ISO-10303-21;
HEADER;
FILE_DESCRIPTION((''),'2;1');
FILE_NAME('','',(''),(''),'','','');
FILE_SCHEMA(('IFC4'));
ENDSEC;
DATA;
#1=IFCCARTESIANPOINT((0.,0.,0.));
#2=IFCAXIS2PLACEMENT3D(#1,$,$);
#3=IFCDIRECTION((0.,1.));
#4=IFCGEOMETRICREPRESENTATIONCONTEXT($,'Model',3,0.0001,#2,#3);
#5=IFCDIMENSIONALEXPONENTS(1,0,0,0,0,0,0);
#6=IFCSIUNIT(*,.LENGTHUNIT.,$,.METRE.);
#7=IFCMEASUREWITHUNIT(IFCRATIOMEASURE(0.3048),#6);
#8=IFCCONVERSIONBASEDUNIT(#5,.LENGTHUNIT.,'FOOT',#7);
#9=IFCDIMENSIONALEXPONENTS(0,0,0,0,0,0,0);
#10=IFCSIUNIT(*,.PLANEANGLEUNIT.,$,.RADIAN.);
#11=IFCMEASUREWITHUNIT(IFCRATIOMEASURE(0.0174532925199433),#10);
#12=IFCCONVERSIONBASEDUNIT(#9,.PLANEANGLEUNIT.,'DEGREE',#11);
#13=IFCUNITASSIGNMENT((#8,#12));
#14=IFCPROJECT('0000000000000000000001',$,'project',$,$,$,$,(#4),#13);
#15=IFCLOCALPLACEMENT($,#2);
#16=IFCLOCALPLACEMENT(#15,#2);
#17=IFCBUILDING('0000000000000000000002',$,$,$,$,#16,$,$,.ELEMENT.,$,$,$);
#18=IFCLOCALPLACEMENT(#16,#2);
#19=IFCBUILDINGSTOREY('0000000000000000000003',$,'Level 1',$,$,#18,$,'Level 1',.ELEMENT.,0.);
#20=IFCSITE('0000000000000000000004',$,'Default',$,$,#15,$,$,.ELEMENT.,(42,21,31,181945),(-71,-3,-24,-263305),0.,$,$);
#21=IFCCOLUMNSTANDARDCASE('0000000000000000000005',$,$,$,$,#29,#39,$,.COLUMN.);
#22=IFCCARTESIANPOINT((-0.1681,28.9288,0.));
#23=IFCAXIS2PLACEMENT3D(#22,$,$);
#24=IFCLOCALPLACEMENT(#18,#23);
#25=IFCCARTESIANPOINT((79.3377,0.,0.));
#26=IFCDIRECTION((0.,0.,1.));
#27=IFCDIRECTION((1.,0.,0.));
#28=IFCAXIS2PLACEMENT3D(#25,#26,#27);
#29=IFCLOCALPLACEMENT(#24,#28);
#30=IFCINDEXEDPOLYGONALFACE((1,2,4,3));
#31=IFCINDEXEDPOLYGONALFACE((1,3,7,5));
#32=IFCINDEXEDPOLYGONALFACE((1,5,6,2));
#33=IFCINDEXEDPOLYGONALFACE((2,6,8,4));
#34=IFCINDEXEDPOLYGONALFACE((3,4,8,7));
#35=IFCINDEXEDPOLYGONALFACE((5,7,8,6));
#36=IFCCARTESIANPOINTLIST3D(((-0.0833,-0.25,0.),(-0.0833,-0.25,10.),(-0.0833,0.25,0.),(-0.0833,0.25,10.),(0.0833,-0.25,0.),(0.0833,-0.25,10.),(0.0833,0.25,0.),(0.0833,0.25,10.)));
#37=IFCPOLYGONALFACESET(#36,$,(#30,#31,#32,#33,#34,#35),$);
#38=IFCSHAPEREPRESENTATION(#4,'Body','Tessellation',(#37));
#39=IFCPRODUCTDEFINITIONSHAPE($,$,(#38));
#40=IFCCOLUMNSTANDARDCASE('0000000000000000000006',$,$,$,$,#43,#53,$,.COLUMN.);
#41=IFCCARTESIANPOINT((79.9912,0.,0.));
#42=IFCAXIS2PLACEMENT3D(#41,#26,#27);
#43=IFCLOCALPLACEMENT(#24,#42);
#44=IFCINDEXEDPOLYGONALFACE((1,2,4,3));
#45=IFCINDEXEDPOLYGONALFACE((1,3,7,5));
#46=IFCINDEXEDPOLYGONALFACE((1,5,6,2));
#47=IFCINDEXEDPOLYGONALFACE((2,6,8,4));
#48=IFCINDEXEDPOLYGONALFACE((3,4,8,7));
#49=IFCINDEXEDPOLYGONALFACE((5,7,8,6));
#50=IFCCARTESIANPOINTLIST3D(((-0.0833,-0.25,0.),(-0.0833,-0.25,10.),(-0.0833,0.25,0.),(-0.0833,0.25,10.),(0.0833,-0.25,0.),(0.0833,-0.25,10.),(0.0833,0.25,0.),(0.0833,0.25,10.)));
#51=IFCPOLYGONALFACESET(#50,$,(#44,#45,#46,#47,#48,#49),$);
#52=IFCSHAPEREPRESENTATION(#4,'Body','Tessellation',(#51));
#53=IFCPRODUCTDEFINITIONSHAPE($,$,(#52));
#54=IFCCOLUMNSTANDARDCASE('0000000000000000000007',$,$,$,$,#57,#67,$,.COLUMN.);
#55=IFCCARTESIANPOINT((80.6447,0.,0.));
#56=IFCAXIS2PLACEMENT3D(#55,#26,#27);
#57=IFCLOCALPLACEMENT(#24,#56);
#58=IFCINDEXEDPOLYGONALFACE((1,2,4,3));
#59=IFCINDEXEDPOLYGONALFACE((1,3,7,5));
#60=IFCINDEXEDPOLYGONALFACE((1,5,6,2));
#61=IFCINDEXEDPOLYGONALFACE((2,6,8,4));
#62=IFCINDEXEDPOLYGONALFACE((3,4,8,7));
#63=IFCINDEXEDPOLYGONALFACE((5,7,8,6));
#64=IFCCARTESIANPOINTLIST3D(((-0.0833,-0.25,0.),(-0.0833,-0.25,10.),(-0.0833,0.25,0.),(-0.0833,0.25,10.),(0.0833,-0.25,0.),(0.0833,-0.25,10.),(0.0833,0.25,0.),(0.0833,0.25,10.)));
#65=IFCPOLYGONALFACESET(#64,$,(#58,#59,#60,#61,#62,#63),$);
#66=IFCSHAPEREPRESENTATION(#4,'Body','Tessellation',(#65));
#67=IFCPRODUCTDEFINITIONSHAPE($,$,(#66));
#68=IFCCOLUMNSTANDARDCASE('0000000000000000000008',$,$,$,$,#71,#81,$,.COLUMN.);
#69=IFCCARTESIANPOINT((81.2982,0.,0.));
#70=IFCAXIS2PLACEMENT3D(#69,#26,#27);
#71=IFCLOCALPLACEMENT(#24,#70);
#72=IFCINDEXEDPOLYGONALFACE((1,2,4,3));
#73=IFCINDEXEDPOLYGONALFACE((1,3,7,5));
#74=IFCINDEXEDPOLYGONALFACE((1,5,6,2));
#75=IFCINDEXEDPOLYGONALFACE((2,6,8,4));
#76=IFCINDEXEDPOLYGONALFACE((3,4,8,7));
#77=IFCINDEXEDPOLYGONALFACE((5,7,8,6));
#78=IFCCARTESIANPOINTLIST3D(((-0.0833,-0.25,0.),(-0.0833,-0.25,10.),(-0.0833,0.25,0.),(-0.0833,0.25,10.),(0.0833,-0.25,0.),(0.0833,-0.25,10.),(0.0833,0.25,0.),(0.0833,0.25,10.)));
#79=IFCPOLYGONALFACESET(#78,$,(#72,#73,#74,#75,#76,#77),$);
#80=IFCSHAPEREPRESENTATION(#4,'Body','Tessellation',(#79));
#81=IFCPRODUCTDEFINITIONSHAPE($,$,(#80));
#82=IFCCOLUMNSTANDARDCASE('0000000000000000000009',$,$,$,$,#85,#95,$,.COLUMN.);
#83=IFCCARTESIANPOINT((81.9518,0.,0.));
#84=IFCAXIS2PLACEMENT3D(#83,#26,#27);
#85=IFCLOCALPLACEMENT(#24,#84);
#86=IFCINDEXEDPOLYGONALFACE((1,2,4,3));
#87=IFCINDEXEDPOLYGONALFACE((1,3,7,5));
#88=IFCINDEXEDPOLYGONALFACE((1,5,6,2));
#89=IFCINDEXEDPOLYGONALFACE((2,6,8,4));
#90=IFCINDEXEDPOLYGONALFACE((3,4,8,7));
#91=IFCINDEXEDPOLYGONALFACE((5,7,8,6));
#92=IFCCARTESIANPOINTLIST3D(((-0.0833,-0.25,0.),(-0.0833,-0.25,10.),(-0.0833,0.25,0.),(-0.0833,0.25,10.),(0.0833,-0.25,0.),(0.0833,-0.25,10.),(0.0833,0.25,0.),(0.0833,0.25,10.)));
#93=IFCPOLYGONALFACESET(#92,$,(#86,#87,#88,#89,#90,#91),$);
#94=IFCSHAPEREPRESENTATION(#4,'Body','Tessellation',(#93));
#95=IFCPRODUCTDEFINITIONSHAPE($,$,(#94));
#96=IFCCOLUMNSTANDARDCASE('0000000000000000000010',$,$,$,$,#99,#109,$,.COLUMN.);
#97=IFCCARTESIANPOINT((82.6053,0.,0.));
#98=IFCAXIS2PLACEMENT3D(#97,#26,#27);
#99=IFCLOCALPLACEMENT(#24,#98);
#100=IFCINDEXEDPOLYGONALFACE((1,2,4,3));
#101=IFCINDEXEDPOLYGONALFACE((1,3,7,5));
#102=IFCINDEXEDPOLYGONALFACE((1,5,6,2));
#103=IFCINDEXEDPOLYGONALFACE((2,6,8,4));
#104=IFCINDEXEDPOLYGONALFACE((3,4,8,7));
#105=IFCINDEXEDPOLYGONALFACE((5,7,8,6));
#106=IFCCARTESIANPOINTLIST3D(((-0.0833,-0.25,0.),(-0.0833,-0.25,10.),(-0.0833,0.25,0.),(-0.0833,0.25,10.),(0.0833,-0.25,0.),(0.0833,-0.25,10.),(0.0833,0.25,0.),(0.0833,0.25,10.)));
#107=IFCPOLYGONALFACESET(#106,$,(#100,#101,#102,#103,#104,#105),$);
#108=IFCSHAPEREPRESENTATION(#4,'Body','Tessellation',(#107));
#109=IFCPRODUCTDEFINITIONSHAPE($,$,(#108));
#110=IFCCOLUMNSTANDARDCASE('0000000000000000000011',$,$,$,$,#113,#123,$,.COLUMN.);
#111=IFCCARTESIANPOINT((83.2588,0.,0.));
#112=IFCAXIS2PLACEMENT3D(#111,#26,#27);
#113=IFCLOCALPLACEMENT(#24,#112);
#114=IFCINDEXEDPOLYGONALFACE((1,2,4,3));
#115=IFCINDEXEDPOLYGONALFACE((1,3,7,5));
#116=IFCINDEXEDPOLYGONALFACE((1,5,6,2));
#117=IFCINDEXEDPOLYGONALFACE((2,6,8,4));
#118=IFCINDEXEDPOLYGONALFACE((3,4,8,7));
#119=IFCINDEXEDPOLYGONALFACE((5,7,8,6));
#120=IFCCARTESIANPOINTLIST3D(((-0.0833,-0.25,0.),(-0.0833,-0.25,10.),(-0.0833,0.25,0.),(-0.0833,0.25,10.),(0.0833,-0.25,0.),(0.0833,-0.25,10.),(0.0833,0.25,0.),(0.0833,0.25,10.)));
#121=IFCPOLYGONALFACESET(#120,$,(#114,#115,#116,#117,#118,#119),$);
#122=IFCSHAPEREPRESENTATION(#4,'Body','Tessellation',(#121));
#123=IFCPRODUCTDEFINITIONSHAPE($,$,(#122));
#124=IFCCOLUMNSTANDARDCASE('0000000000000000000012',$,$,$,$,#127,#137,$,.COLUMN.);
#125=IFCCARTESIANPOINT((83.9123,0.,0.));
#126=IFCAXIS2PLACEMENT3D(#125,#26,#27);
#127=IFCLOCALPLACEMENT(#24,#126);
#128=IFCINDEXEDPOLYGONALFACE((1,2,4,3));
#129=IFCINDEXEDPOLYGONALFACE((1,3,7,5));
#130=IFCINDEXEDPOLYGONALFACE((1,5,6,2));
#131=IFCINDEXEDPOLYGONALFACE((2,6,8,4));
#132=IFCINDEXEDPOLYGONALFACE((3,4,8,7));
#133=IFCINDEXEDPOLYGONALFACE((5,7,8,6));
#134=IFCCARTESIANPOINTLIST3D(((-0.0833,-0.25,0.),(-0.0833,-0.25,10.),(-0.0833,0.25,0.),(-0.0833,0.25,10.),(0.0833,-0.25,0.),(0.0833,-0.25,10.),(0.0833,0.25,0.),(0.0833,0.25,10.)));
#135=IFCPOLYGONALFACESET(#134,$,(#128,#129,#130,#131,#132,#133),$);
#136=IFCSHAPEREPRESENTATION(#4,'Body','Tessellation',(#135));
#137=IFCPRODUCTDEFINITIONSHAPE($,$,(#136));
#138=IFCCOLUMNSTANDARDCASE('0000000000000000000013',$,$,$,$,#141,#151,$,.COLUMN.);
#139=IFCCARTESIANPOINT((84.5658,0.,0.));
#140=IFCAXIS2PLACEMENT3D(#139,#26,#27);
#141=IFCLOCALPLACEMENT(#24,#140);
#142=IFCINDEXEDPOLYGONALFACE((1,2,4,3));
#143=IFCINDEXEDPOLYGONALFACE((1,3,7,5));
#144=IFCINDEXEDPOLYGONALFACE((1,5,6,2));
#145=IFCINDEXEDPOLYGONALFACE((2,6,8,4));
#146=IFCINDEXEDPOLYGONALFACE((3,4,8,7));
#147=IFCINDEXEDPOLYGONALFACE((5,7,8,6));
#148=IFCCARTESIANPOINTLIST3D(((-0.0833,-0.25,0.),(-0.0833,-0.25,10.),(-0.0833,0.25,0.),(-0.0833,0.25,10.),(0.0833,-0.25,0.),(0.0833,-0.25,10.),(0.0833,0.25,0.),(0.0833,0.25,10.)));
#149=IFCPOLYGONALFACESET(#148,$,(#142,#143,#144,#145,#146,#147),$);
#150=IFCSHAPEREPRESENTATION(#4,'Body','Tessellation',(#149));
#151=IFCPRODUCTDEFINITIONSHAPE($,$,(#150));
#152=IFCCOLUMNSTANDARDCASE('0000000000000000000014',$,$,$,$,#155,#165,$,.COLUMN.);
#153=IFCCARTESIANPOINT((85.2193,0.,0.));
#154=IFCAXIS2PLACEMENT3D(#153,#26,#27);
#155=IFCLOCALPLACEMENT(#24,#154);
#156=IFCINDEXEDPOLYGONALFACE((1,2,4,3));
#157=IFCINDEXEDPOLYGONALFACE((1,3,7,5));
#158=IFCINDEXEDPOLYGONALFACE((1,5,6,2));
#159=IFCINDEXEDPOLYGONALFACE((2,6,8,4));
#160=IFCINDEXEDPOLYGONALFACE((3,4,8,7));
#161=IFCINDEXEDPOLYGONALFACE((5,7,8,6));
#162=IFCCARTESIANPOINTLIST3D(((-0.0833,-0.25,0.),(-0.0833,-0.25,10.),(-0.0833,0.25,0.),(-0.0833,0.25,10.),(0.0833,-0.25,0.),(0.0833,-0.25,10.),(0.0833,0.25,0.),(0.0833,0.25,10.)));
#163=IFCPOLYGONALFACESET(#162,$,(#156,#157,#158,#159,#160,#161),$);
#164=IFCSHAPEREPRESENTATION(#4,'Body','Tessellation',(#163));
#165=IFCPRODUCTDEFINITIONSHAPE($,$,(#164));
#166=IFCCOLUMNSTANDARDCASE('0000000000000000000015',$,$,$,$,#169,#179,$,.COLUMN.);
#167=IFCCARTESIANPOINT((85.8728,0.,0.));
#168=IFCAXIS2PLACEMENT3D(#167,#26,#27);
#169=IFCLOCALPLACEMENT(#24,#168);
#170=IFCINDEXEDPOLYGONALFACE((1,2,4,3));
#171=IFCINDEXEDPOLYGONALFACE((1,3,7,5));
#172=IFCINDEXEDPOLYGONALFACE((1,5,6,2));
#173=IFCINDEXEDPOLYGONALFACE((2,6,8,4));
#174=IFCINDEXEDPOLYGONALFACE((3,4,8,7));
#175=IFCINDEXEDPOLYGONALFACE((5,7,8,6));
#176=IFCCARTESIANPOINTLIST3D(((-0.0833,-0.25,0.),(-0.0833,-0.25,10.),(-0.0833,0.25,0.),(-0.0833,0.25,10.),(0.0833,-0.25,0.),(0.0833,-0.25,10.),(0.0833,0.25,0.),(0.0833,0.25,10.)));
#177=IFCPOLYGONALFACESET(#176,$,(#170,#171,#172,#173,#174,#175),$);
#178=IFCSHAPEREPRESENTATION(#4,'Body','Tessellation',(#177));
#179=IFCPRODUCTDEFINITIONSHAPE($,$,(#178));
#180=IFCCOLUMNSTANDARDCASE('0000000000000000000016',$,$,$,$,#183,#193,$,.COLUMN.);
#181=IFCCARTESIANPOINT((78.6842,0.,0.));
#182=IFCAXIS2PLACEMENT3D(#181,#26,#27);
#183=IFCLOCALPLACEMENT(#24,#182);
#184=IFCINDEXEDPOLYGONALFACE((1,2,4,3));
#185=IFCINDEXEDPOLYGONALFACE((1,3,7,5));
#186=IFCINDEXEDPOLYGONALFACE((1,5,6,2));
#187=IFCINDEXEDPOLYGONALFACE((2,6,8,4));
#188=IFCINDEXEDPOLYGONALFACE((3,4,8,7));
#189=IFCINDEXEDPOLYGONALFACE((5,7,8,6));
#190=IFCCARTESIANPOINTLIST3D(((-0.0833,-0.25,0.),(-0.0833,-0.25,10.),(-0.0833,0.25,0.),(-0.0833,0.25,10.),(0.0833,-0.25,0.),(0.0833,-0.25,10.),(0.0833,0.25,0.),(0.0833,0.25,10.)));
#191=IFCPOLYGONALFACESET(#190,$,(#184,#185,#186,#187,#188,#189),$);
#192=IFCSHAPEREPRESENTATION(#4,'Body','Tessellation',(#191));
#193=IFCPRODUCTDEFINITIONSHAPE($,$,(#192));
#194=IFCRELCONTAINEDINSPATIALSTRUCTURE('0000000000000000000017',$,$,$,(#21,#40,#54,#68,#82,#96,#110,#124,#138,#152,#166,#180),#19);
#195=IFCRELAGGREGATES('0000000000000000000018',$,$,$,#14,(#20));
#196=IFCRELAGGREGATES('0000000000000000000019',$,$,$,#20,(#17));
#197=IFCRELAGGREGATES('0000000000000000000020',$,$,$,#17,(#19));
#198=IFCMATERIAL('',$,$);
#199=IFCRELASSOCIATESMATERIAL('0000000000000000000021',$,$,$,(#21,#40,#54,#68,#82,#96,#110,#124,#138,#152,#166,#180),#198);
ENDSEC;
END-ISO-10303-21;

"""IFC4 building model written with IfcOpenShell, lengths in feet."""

from ifc_helpers import new_model, entity, si_unit, converted_unit, direction, frame, origin, place, context, project, spatial, rectangle, extrude, material, element, save


model = new_model("IFC4")

# Units and contexts
model_context = context("Model", 3, precision=0.0001, world=origin(), true_north=direction((0.0, 1.0)))
ifc_project = project(units=[converted_unit("LENGTHUNIT", "FOOT", entity("IfcRatioMeasure", 0.3048), si_unit("LENGTHUNIT", "METRE"), dimensions=[1, 0, 0, 0, 0, 0, 0]), converted_unit("PLANEANGLEUNIT", "DEGREE", entity("IfcRatioMeasure", 0.0174532925199433), si_unit("PLANEANGLEUNIT", "RADIAN"), dimensions=[0, 0, 0, 0, 0, 0, 0])], contexts=[model_context])

# Site, building, storey
site_placement = place(None, origin())
site = spatial("IfcSite", under=ifc_project, at=site_placement, Name="Default", CompositionType="ELEMENT", RefLatitude=(42, 21, 31, 181945), RefLongitude=(-71, -3, -24, -263305), RefElevation=0.0)
building_placement = place(site_placement, origin())
building = spatial("IfcBuilding", under=site, at=building_placement, CompositionType="ELEMENT")
storey_placement = place(building_placement, origin())
storey = spatial("IfcBuildingStorey", under=building, at=storey_placement, Name="Level 1", LongName="Level 1", CompositionType="ELEMENT", Elevation=0.0)

# Columns
ifc_material = material(Name="")
placement = place(storey_placement, frame((-0.1681, 28.9288, 0.0)))
for number, where, z_axis, x_axis in (
    (1, (79.3377, 0.0, 0.0), (0.0, 0.0, 1.0), (1.0, 0.0, 0.0)),
    (2, (79.9912, 0.0, 0.0), (0.0, 0.0, 1.0), (1.0, 0.0, 0.0)),
    (3, (80.6447, 0.0, 0.0), (0.0, 0.0, 1.0), (1.0, 0.0, 0.0)),
    (4, (81.2982, 0.0, 0.0), (0.0, 0.0, 1.0), (1.0, 0.0, 0.0)),
    (5, (81.9518, 0.0, 0.0), (0.0, 0.0, 1.0), (1.0, 0.0, 0.0)),
    (6, (82.6053, 0.0, 0.0), (0.0, 0.0, 1.0), (1.0, 0.0, 0.0)),
    (7, (83.2588, 0.0, 0.0), (0.0, 0.0, 1.0), (1.0, 0.0, 0.0)),
    (8, (83.9123, 0.0, 0.0), (0.0, 0.0, 1.0), (1.0, 0.0, 0.0)),
    (9, (84.5658, 0.0, 0.0), (0.0, 0.0, 1.0), (1.0, 0.0, 0.0)),
    (10, (85.2193, 0.0, 0.0), (0.0, 0.0, 1.0), (1.0, 0.0, 0.0)),
    (11, (85.8728, 0.0, 0.0), (0.0, 0.0, 1.0), (1.0, 0.0, 0.0)),
    (12, (78.6842, 0.0, 0.0), (0.0, 0.0, 1.0), (1.0, 0.0, 0.0)),
):
    element("IfcColumnStandardCase", number, at=place(placement, frame(where, z_axis=z_axis, x_axis=x_axis)), inside=storey, material=ifc_material, PredefinedType="COLUMN", context=model_context, shape_type="SweptSolid", body=[
        extrude(rectangle(XDim=0.1667, YDim=0.5), origin(), (0.0, 0.0, 1.0), 10.0),
    ])

save(model, "model.ifc")
